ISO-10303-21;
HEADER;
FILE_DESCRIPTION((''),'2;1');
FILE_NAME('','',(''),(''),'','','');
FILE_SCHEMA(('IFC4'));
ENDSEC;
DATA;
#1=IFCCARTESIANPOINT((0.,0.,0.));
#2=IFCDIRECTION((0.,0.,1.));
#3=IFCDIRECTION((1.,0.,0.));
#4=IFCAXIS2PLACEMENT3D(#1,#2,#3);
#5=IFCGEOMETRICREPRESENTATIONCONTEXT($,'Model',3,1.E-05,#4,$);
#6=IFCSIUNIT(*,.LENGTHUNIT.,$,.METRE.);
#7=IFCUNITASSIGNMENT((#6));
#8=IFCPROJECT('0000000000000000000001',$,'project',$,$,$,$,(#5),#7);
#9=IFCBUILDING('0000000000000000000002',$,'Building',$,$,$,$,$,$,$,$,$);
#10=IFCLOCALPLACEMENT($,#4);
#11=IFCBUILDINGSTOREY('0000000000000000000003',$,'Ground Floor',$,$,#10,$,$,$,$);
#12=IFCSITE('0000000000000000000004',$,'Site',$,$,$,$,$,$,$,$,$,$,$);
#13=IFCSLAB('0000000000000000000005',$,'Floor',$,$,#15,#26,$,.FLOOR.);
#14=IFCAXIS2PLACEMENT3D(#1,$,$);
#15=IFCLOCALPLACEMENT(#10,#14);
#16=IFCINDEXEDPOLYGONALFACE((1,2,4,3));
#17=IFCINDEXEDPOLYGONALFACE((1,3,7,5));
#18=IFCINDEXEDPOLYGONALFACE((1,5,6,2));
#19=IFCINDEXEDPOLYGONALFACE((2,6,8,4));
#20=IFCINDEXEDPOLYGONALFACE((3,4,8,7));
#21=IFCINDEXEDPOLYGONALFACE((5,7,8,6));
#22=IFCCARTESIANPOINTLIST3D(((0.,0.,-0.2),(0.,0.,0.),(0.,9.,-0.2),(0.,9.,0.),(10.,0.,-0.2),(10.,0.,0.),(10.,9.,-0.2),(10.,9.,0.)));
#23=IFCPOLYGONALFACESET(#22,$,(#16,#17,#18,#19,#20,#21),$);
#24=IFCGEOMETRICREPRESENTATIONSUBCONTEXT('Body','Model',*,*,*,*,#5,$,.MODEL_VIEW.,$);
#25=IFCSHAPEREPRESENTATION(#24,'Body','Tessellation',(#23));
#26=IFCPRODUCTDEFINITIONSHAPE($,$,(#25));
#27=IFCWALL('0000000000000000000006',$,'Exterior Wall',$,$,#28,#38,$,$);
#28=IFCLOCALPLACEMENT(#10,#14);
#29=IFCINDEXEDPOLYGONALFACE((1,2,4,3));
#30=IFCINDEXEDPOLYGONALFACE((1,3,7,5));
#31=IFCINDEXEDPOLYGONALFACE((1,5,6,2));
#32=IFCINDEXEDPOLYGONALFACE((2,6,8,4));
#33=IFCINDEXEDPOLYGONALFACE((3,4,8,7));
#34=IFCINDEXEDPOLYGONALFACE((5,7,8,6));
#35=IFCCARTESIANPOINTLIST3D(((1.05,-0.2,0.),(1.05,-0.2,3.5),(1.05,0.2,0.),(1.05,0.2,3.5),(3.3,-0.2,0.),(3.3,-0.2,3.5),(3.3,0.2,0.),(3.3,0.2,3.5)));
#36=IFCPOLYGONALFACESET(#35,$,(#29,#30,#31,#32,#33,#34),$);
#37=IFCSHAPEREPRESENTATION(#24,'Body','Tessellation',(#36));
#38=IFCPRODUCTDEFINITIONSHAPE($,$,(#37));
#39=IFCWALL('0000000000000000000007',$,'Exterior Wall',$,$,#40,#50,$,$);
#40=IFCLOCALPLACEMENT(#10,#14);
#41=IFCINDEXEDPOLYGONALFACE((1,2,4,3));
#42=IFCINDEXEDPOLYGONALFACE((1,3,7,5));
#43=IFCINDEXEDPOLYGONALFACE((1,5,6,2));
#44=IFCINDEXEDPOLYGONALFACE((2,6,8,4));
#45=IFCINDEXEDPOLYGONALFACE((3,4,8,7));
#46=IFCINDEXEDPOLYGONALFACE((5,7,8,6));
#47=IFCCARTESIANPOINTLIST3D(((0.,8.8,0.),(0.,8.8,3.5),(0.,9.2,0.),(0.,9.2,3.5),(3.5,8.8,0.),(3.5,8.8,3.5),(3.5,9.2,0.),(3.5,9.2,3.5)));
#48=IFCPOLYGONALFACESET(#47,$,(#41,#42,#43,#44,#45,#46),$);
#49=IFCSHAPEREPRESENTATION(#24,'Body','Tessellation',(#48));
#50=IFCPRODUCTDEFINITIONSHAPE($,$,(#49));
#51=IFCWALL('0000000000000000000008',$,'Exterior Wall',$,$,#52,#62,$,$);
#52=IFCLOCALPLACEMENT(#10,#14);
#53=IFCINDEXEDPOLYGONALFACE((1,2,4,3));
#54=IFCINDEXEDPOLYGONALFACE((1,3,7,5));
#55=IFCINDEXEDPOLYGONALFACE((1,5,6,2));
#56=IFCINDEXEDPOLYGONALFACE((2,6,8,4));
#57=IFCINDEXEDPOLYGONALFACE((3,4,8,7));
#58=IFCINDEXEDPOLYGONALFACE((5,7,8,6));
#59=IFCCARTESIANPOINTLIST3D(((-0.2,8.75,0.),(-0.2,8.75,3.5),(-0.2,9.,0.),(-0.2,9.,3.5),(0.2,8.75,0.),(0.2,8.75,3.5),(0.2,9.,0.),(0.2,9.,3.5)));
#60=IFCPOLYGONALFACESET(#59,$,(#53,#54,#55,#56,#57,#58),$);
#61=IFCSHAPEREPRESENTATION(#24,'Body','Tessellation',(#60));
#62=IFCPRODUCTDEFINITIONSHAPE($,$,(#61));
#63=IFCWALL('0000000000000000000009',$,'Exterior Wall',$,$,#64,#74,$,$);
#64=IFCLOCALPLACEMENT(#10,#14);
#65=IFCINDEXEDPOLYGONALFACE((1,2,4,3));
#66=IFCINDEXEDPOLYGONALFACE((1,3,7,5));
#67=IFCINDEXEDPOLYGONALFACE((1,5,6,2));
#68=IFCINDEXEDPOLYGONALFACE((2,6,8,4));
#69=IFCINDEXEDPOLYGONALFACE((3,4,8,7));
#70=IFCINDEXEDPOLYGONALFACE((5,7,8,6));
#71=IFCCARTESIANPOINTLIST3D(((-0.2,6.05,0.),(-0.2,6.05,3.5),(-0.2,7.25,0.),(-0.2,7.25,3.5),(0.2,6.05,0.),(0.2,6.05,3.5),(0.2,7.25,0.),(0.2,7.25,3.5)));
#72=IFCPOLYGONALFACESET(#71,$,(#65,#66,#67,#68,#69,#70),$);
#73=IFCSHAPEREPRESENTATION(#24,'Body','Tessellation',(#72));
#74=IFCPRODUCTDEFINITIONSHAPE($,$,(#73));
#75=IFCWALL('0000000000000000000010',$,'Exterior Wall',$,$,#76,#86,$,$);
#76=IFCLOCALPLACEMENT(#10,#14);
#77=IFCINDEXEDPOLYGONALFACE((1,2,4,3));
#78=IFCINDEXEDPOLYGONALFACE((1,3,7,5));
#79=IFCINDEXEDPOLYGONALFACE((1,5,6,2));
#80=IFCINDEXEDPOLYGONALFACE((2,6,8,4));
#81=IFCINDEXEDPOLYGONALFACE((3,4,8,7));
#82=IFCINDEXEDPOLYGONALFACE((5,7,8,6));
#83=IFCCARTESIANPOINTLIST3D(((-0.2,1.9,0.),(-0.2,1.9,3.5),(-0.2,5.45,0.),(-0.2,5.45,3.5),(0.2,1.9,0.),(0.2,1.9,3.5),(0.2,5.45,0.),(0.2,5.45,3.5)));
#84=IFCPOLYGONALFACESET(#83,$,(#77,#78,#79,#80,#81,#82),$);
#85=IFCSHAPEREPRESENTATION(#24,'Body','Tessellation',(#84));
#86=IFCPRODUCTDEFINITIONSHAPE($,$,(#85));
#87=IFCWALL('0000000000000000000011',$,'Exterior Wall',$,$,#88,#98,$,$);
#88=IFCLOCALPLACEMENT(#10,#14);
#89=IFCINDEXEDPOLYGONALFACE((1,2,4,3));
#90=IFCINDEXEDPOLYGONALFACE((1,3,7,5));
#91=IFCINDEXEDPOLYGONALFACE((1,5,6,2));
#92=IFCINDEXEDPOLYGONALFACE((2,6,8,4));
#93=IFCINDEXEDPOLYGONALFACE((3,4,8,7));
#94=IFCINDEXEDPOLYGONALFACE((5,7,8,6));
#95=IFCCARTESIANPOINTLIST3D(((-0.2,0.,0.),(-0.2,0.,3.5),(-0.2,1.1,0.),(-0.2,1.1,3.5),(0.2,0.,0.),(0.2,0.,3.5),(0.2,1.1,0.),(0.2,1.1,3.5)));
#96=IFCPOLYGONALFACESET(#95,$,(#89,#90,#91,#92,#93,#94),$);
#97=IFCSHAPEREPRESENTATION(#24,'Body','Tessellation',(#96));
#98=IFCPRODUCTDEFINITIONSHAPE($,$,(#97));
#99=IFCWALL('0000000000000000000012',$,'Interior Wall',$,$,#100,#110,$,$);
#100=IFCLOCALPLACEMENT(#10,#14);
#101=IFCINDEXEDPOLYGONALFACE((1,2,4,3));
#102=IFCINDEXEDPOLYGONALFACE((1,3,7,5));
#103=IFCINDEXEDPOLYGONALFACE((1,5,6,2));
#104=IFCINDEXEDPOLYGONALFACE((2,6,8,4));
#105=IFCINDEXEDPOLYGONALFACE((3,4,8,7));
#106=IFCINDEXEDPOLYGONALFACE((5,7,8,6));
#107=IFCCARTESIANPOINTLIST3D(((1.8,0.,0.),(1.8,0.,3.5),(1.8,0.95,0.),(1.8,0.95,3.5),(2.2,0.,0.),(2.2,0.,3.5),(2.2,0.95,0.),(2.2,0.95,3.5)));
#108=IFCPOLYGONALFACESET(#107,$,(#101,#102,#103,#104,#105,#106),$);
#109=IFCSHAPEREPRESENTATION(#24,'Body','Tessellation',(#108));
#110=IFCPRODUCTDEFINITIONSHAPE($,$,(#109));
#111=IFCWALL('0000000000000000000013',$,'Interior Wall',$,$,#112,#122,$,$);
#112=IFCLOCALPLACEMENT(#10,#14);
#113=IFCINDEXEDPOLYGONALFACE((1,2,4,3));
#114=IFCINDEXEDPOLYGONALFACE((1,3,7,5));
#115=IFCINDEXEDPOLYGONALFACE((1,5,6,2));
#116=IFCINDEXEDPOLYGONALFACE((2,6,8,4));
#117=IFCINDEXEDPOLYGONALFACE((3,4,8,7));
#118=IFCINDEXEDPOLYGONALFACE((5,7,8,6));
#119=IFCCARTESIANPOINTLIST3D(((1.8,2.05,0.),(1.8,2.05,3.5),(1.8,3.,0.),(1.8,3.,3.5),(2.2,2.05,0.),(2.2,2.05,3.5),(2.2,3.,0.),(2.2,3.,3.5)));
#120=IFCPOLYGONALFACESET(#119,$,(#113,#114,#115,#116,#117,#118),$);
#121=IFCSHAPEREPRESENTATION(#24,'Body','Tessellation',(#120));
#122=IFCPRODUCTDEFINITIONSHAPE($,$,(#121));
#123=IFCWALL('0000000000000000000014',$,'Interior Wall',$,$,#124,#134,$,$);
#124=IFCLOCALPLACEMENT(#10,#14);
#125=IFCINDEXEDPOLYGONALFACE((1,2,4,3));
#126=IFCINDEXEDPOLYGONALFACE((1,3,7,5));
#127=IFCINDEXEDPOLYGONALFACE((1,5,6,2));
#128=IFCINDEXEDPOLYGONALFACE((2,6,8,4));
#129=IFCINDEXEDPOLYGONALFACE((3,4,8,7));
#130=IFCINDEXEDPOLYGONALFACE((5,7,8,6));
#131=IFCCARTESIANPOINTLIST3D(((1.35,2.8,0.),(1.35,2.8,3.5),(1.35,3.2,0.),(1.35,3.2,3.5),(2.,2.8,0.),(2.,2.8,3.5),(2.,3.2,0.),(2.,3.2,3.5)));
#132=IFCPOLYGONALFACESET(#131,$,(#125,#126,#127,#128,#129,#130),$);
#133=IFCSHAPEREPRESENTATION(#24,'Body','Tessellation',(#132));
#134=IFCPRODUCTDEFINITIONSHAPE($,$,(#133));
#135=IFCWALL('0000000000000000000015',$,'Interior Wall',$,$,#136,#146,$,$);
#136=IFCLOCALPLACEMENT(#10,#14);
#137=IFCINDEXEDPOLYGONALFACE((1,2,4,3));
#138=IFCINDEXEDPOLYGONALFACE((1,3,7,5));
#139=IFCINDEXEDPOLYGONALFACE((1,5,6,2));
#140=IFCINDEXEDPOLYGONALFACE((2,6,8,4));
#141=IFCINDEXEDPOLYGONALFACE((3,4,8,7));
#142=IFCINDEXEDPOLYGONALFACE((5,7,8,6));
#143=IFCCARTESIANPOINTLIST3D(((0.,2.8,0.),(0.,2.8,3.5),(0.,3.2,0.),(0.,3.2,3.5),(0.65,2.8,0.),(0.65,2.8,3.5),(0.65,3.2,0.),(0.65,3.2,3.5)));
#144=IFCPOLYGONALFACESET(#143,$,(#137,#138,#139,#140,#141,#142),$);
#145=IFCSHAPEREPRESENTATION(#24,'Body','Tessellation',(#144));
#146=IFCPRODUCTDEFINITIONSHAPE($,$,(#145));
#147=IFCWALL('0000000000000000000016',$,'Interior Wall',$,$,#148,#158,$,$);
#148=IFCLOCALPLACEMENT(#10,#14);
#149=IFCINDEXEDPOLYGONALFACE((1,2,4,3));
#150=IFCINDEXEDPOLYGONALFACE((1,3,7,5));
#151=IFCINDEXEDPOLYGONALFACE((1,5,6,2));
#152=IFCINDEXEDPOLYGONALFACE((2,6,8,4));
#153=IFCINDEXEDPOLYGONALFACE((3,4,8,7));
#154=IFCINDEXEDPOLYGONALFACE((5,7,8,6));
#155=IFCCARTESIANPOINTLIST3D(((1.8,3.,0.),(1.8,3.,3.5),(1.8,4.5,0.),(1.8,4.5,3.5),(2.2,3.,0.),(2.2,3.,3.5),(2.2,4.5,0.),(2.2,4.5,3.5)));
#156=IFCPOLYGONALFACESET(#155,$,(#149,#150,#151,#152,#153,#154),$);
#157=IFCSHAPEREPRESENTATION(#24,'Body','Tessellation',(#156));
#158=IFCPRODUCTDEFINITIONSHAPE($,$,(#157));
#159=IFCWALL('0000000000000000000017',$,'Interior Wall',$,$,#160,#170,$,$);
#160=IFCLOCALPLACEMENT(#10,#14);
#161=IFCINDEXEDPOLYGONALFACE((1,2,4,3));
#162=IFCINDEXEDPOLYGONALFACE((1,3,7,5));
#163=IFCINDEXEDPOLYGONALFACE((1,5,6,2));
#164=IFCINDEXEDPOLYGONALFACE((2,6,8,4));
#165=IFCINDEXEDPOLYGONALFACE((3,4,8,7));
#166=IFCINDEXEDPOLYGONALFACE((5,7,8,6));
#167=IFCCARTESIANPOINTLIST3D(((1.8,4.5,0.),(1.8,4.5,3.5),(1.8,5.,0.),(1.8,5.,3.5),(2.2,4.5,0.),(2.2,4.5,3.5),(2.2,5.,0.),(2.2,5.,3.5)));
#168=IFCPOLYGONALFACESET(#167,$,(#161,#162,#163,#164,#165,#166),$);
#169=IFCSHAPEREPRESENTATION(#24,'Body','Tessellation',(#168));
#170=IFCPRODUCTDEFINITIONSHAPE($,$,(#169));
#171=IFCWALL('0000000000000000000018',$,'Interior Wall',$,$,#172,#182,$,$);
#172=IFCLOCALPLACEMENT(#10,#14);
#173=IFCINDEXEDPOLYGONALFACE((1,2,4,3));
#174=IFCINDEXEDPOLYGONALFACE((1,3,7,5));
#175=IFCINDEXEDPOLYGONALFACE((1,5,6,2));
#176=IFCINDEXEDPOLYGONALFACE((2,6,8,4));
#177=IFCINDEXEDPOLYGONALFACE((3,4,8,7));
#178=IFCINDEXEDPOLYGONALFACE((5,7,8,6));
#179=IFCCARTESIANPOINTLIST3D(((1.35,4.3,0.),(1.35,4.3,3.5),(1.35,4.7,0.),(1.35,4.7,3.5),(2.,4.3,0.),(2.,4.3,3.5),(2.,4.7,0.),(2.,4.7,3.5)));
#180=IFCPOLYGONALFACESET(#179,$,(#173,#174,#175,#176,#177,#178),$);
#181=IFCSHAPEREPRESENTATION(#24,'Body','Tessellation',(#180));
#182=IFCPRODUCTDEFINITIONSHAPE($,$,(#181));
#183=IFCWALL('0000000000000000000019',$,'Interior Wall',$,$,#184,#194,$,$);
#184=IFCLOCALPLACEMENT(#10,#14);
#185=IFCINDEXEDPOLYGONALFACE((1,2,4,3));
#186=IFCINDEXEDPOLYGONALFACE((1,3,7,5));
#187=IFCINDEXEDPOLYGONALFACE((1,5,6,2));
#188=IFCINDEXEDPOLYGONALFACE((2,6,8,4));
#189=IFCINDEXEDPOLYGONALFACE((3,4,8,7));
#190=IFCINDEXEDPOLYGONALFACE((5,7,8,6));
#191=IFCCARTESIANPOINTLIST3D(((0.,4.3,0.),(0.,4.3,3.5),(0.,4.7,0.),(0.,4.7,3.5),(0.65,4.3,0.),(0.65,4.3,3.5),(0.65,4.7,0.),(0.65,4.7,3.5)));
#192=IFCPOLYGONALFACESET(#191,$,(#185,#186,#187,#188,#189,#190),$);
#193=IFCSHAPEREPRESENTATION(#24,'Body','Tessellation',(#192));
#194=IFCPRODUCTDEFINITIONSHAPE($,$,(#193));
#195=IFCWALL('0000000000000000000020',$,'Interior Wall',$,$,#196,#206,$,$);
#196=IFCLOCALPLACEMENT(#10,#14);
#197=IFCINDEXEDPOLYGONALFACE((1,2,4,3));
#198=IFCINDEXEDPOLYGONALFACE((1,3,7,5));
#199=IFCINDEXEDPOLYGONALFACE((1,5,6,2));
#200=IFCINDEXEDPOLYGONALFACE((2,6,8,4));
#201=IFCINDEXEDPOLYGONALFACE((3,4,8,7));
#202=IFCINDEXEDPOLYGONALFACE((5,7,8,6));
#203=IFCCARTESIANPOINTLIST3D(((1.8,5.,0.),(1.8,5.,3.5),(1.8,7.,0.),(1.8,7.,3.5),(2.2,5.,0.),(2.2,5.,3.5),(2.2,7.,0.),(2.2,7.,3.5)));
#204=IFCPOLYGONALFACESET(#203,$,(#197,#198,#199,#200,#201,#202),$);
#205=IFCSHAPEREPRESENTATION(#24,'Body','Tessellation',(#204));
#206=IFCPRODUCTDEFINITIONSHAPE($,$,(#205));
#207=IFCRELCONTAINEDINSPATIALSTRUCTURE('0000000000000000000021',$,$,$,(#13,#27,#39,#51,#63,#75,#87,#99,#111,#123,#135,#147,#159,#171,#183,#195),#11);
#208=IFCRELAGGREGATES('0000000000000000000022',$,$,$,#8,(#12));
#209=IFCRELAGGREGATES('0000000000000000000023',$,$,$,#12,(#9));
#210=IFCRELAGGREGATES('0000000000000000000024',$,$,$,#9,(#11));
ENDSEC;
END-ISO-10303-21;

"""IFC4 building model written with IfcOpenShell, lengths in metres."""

from ifc_helpers import new_model, si_unit, frame, origin_with_axes, place, context, subcontext, project, spatial, indexed_curve, outline, extrude, element, save


model = new_model("IFC4")

# Units and contexts
model_context = context("Model", 3, precision=1e-05, world=origin_with_axes())
body_context = subcontext(model_context, "Body", "Model", "MODEL_VIEW")
ifc_project = project(units=[si_unit("LENGTHUNIT", "METRE")], contexts=[model_context])

# Site, building, storey
site = spatial("IfcSite", under=ifc_project, Name="Site")
building = spatial("IfcBuilding", under=site, Name="Building")
storey_placement = place(None, origin_with_axes())
storey = spatial("IfcBuildingStorey", under=building, at=storey_placement, Name="Ground Floor")

# Slab
slab_placement = place(storey_placement, frame((0.0, 0.0, -0.2), z_axis=(0.0, 0.0, 1.0), x_axis=(1.0, 0.0, 0.0)))
element("IfcSlab", 1, at=slab_placement, inside=storey, Name="Floor", PredefinedType="FLOOR", context=body_context, shape_type="SweptSolid", body=[
    extrude(outline(indexed_curve([(0.0, 0.0), (10.0, 0.0), (10.0, 9.0), (0.0, 9.0)])), None, (0.0, 0.0, 1.0), 0.2),
])

# Walls
wall_1_placement = place(storey_placement, frame((1.05, 0.0, 0.0), z_axis=(0.0, 0.0, 1.0), x_axis=(1.0, 0.0, 0.0)))
element("IfcWall", 2, at=wall_1_placement, inside=storey, Name="Exterior Wall", context=body_context, shape_type="SweptSolid", body=[
    extrude(outline(indexed_curve([(0.0, 0.0), (0.0, 0.4), (2.25, 0.4), (2.25, 0.0), (0.0, 0.0)], self_intersect=False)), frame((0.0, -0.2, 0.0), z_axis=(0.0, 0.0, 1.0), x_axis=(1.0, 0.0, 0.0)), (0.0, 0.0, 1.0), 3.5),
])
wall_2_placement = place(storey_placement, frame((3.5, 9.0, 0.0), z_axis=(0.0, 0.0, 1.0), x_axis=(-1.0, 0.0, 0.0)))
element("IfcWall", 3, at=wall_2_placement, inside=storey, Name="Exterior Wall", context=body_context, shape_type="SweptSolid", body=[
    extrude(outline(indexed_curve([(0.0, 0.0), (0.0, 0.4), (3.5, 0.4), (3.5, 0.0), (0.0, 0.0)], self_intersect=False)), frame((0.0, -0.2, 0.0), z_axis=(0.0, 0.0, 1.0), x_axis=(1.0, 0.0, 0.0)), (0.0, 0.0, 1.0), 3.5),
])
wall_3_placement = place(storey_placement, frame((0.0, 9.0, 0.0), z_axis=(0.0, 0.0, 1.0), x_axis=(0.0, -1.0, 0.0)))
element("IfcWall", 4, at=wall_3_placement, inside=storey, Name="Exterior Wall", context=body_context, shape_type="SweptSolid", body=[
    extrude(outline(indexed_curve([(0.0, 0.0), (0.0, 0.4), (0.25, 0.4), (0.25, 0.0), (0.0, 0.0)], self_intersect=False)), frame((0.0, -0.2, 0.0), z_axis=(0.0, 0.0, 1.0), x_axis=(1.0, 0.0, 0.0)), (0.0, 0.0, 1.0), 3.5),
])
wall_4_placement = place(storey_placement, frame((0.0, 7.25, 0.0), z_axis=(0.0, 0.0, 1.0), x_axis=(0.0, -1.0, 0.0)))
element("IfcWall", 5, at=wall_4_placement, inside=storey, Name="Exterior Wall", context=body_context, shape_type="SweptSolid", body=[
    extrude(outline(indexed_curve([(0.0, 0.0), (0.0, 0.4), (1.2, 0.4), (1.2, 0.0), (0.0, 0.0)], self_intersect=False)), frame((0.0, -0.2, 0.0), z_axis=(0.0, 0.0, 1.0), x_axis=(1.0, 0.0, 0.0)), (0.0, 0.0, 1.0), 3.5),
])
wall_5_placement = place(storey_placement, frame((0.0, 5.45, 0.0), z_axis=(0.0, 0.0, 1.0), x_axis=(0.0, -1.0, 0.0)))
element("IfcWall", 6, at=wall_5_placement, inside=storey, Name="Exterior Wall", context=body_context, shape_type="SweptSolid", body=[
    extrude(outline(indexed_curve([(0.0, 0.0), (0.0, 0.4), (3.55, 0.4), (3.55, 0.0), (0.0, 0.0)], self_intersect=False)), frame((0.0, -0.2, 0.0), z_axis=(0.0, 0.0, 1.0), x_axis=(1.0, 0.0, 0.0)), (0.0, 0.0, 1.0), 3.5),
])
wall_6_placement = place(storey_placement, frame((0.0, 1.1, 0.0), z_axis=(0.0, 0.0, 1.0), x_axis=(0.0, -1.0, 0.0)))
element("IfcWall", 7, at=wall_6_placement, inside=storey, Name="Exterior Wall", context=body_context, shape_type="SweptSolid", body=[
    extrude(outline(indexed_curve([(0.0, 0.0), (0.0, 0.4), (1.1, 0.4), (1.1, 0.0), (0.0, 0.0)], self_intersect=False)), frame((0.0, -0.2, 0.0), z_axis=(0.0, 0.0, 1.0), x_axis=(1.0, 0.0, 0.0)), (0.0, 0.0, 1.0), 3.5),
])
wall_7_placement = place(storey_placement, frame((2.0, 0.0, 0.0), z_axis=(0.0, 0.0, 1.0), x_axis=(0.0, 1.0, 0.0)))
element("IfcWall", 8, at=wall_7_placement, inside=storey, Name="Interior Wall", context=body_context, shape_type="SweptSolid", body=[
    extrude(outline(indexed_curve([(0.0, 0.0), (0.0, 0.4), (0.95, 0.4), (0.95, 0.0), (0.0, 0.0)], self_intersect=False)), frame((0.0, -0.2, 0.0), z_axis=(0.0, 0.0, 1.0), x_axis=(1.0, 0.0, 0.0)), (0.0, 0.0, 1.0), 3.5),
])
wall_8_placement = place(storey_placement, frame((2.0, 2.05, 0.0), z_axis=(0.0, 0.0, 1.0), x_axis=(0.0, 1.0, 0.0)))
element("IfcWall", 9, at=wall_8_placement, inside=storey, Name="Interior Wall", context=body_context, shape_type="SweptSolid", body=[
    extrude(outline(indexed_curve([(0.0, 0.0), (0.0, 0.4), (0.95, 0.4), (0.95, 0.0), (0.0, 0.0)], self_intersect=False)), frame((0.0, -0.2, 0.0), z_axis=(0.0, 0.0, 1.0), x_axis=(1.0, 0.0, 0.0)), (0.0, 0.0, 1.0), 3.5),
])
for number, where, z_axis, x_axis, name in (
    (10, (2.0, 3.0, 0.0), (0.0, 0.0, 1.0), (-1.0, 0.0, 0.0), "Interior Wall"),
    (11, (0.65, 3.0, 0.0), (0.0, 0.0, 1.0), (-1.0, 0.0, 0.0), "Interior Wall"),
):
    element("IfcWall", number, at=place(storey_placement, frame(where, z_axis=z_axis, x_axis=x_axis)), inside=storey, Name=name, context=body_context, shape_type="SweptSolid", body=[
        extrude(outline(indexed_curve([(0.0, 0.0), (0.0, 0.4), (0.65, 0.4), (0.65, 0.0), (0.0, 0.0)], self_intersect=False)), frame((0.0, -0.2, 0.0), z_axis=(0.0, 0.0, 1.0), x_axis=(1.0, 0.0, 0.0)), (0.0, 0.0, 1.0), 3.5),
    ])
wall_9_placement = place(storey_placement, frame((2.0, 4.5, 0.0), z_axis=(0.0, 0.0, 1.0), x_axis=(0.0, -1.0, 0.0)))
element("IfcWall", 12, at=wall_9_placement, inside=storey, Name="Interior Wall", context=body_context, shape_type="SweptSolid", body=[
    extrude(outline(indexed_curve([(0.0, 0.0), (0.0, 0.4), (1.5, 0.4), (1.5, 0.0), (0.0, 0.0)], self_intersect=False)), frame((0.0, -0.2, 0.0), z_axis=(0.0, 0.0, 1.0), x_axis=(1.0, 0.0, 0.0)), (0.0, 0.0, 1.0), 3.5),
])
wall_10_placement = place(storey_placement, frame((2.0, 5.0, 0.0), z_axis=(0.0, 0.0, 1.0), x_axis=(0.0, -1.0, 0.0)))
element("IfcWall", 13, at=wall_10_placement, inside=storey, Name="Interior Wall", context=body_context, shape_type="SweptSolid", body=[
    extrude(outline(indexed_curve([(0.0, 0.0), (0.0, 0.4), (0.5, 0.4), (0.5, 0.0), (0.0, 0.0)], self_intersect=False)), frame((0.0, -0.2, 0.0), z_axis=(0.0, 0.0, 1.0), x_axis=(1.0, 0.0, 0.0)), (0.0, 0.0, 1.0), 3.5),
])
for number, where, z_axis, x_axis, name in (
    (14, (2.0, 4.5, 0.0), (0.0, 0.0, 1.0), (-1.0, 0.0, 0.0), "Interior Wall"),
    (15, (0.65, 4.5, 0.0), (0.0, 0.0, 1.0), (-1.0, 0.0, 0.0), "Interior Wall"),
):
    element("IfcWall", number, at=place(storey_placement, frame(where, z_axis=z_axis, x_axis=x_axis)), inside=storey, Name=name, context=body_context, shape_type="SweptSolid", body=[
        extrude(outline(indexed_curve([(0.0, 0.0), (0.0, 0.4), (0.65, 0.4), (0.65, 0.0), (0.0, 0.0)], self_intersect=False)), frame((0.0, -0.2, 0.0), z_axis=(0.0, 0.0, 1.0), x_axis=(1.0, 0.0, 0.0)), (0.0, 0.0, 1.0), 3.5),
    ])
wall_11_placement = place(storey_placement, frame((2.0, 5.0, 0.0), z_axis=(0.0, 0.0, 1.0), x_axis=(0.0, 1.0, 0.0)))
element("IfcWall", 16, at=wall_11_placement, inside=storey, Name="Interior Wall", context=body_context, shape_type="SweptSolid", body=[
    extrude(outline(indexed_curve([(0.0, 0.0), (0.0, 0.4), (2.0, 0.4), (2.0, 0.0), (0.0, 0.0)], self_intersect=False)), frame((0.0, -0.2, 0.0), z_axis=(0.0, 0.0, 1.0), x_axis=(1.0, 0.0, 0.0)), (0.0, 0.0, 1.0), 3.5),
])

save(model, "model.ifc")
